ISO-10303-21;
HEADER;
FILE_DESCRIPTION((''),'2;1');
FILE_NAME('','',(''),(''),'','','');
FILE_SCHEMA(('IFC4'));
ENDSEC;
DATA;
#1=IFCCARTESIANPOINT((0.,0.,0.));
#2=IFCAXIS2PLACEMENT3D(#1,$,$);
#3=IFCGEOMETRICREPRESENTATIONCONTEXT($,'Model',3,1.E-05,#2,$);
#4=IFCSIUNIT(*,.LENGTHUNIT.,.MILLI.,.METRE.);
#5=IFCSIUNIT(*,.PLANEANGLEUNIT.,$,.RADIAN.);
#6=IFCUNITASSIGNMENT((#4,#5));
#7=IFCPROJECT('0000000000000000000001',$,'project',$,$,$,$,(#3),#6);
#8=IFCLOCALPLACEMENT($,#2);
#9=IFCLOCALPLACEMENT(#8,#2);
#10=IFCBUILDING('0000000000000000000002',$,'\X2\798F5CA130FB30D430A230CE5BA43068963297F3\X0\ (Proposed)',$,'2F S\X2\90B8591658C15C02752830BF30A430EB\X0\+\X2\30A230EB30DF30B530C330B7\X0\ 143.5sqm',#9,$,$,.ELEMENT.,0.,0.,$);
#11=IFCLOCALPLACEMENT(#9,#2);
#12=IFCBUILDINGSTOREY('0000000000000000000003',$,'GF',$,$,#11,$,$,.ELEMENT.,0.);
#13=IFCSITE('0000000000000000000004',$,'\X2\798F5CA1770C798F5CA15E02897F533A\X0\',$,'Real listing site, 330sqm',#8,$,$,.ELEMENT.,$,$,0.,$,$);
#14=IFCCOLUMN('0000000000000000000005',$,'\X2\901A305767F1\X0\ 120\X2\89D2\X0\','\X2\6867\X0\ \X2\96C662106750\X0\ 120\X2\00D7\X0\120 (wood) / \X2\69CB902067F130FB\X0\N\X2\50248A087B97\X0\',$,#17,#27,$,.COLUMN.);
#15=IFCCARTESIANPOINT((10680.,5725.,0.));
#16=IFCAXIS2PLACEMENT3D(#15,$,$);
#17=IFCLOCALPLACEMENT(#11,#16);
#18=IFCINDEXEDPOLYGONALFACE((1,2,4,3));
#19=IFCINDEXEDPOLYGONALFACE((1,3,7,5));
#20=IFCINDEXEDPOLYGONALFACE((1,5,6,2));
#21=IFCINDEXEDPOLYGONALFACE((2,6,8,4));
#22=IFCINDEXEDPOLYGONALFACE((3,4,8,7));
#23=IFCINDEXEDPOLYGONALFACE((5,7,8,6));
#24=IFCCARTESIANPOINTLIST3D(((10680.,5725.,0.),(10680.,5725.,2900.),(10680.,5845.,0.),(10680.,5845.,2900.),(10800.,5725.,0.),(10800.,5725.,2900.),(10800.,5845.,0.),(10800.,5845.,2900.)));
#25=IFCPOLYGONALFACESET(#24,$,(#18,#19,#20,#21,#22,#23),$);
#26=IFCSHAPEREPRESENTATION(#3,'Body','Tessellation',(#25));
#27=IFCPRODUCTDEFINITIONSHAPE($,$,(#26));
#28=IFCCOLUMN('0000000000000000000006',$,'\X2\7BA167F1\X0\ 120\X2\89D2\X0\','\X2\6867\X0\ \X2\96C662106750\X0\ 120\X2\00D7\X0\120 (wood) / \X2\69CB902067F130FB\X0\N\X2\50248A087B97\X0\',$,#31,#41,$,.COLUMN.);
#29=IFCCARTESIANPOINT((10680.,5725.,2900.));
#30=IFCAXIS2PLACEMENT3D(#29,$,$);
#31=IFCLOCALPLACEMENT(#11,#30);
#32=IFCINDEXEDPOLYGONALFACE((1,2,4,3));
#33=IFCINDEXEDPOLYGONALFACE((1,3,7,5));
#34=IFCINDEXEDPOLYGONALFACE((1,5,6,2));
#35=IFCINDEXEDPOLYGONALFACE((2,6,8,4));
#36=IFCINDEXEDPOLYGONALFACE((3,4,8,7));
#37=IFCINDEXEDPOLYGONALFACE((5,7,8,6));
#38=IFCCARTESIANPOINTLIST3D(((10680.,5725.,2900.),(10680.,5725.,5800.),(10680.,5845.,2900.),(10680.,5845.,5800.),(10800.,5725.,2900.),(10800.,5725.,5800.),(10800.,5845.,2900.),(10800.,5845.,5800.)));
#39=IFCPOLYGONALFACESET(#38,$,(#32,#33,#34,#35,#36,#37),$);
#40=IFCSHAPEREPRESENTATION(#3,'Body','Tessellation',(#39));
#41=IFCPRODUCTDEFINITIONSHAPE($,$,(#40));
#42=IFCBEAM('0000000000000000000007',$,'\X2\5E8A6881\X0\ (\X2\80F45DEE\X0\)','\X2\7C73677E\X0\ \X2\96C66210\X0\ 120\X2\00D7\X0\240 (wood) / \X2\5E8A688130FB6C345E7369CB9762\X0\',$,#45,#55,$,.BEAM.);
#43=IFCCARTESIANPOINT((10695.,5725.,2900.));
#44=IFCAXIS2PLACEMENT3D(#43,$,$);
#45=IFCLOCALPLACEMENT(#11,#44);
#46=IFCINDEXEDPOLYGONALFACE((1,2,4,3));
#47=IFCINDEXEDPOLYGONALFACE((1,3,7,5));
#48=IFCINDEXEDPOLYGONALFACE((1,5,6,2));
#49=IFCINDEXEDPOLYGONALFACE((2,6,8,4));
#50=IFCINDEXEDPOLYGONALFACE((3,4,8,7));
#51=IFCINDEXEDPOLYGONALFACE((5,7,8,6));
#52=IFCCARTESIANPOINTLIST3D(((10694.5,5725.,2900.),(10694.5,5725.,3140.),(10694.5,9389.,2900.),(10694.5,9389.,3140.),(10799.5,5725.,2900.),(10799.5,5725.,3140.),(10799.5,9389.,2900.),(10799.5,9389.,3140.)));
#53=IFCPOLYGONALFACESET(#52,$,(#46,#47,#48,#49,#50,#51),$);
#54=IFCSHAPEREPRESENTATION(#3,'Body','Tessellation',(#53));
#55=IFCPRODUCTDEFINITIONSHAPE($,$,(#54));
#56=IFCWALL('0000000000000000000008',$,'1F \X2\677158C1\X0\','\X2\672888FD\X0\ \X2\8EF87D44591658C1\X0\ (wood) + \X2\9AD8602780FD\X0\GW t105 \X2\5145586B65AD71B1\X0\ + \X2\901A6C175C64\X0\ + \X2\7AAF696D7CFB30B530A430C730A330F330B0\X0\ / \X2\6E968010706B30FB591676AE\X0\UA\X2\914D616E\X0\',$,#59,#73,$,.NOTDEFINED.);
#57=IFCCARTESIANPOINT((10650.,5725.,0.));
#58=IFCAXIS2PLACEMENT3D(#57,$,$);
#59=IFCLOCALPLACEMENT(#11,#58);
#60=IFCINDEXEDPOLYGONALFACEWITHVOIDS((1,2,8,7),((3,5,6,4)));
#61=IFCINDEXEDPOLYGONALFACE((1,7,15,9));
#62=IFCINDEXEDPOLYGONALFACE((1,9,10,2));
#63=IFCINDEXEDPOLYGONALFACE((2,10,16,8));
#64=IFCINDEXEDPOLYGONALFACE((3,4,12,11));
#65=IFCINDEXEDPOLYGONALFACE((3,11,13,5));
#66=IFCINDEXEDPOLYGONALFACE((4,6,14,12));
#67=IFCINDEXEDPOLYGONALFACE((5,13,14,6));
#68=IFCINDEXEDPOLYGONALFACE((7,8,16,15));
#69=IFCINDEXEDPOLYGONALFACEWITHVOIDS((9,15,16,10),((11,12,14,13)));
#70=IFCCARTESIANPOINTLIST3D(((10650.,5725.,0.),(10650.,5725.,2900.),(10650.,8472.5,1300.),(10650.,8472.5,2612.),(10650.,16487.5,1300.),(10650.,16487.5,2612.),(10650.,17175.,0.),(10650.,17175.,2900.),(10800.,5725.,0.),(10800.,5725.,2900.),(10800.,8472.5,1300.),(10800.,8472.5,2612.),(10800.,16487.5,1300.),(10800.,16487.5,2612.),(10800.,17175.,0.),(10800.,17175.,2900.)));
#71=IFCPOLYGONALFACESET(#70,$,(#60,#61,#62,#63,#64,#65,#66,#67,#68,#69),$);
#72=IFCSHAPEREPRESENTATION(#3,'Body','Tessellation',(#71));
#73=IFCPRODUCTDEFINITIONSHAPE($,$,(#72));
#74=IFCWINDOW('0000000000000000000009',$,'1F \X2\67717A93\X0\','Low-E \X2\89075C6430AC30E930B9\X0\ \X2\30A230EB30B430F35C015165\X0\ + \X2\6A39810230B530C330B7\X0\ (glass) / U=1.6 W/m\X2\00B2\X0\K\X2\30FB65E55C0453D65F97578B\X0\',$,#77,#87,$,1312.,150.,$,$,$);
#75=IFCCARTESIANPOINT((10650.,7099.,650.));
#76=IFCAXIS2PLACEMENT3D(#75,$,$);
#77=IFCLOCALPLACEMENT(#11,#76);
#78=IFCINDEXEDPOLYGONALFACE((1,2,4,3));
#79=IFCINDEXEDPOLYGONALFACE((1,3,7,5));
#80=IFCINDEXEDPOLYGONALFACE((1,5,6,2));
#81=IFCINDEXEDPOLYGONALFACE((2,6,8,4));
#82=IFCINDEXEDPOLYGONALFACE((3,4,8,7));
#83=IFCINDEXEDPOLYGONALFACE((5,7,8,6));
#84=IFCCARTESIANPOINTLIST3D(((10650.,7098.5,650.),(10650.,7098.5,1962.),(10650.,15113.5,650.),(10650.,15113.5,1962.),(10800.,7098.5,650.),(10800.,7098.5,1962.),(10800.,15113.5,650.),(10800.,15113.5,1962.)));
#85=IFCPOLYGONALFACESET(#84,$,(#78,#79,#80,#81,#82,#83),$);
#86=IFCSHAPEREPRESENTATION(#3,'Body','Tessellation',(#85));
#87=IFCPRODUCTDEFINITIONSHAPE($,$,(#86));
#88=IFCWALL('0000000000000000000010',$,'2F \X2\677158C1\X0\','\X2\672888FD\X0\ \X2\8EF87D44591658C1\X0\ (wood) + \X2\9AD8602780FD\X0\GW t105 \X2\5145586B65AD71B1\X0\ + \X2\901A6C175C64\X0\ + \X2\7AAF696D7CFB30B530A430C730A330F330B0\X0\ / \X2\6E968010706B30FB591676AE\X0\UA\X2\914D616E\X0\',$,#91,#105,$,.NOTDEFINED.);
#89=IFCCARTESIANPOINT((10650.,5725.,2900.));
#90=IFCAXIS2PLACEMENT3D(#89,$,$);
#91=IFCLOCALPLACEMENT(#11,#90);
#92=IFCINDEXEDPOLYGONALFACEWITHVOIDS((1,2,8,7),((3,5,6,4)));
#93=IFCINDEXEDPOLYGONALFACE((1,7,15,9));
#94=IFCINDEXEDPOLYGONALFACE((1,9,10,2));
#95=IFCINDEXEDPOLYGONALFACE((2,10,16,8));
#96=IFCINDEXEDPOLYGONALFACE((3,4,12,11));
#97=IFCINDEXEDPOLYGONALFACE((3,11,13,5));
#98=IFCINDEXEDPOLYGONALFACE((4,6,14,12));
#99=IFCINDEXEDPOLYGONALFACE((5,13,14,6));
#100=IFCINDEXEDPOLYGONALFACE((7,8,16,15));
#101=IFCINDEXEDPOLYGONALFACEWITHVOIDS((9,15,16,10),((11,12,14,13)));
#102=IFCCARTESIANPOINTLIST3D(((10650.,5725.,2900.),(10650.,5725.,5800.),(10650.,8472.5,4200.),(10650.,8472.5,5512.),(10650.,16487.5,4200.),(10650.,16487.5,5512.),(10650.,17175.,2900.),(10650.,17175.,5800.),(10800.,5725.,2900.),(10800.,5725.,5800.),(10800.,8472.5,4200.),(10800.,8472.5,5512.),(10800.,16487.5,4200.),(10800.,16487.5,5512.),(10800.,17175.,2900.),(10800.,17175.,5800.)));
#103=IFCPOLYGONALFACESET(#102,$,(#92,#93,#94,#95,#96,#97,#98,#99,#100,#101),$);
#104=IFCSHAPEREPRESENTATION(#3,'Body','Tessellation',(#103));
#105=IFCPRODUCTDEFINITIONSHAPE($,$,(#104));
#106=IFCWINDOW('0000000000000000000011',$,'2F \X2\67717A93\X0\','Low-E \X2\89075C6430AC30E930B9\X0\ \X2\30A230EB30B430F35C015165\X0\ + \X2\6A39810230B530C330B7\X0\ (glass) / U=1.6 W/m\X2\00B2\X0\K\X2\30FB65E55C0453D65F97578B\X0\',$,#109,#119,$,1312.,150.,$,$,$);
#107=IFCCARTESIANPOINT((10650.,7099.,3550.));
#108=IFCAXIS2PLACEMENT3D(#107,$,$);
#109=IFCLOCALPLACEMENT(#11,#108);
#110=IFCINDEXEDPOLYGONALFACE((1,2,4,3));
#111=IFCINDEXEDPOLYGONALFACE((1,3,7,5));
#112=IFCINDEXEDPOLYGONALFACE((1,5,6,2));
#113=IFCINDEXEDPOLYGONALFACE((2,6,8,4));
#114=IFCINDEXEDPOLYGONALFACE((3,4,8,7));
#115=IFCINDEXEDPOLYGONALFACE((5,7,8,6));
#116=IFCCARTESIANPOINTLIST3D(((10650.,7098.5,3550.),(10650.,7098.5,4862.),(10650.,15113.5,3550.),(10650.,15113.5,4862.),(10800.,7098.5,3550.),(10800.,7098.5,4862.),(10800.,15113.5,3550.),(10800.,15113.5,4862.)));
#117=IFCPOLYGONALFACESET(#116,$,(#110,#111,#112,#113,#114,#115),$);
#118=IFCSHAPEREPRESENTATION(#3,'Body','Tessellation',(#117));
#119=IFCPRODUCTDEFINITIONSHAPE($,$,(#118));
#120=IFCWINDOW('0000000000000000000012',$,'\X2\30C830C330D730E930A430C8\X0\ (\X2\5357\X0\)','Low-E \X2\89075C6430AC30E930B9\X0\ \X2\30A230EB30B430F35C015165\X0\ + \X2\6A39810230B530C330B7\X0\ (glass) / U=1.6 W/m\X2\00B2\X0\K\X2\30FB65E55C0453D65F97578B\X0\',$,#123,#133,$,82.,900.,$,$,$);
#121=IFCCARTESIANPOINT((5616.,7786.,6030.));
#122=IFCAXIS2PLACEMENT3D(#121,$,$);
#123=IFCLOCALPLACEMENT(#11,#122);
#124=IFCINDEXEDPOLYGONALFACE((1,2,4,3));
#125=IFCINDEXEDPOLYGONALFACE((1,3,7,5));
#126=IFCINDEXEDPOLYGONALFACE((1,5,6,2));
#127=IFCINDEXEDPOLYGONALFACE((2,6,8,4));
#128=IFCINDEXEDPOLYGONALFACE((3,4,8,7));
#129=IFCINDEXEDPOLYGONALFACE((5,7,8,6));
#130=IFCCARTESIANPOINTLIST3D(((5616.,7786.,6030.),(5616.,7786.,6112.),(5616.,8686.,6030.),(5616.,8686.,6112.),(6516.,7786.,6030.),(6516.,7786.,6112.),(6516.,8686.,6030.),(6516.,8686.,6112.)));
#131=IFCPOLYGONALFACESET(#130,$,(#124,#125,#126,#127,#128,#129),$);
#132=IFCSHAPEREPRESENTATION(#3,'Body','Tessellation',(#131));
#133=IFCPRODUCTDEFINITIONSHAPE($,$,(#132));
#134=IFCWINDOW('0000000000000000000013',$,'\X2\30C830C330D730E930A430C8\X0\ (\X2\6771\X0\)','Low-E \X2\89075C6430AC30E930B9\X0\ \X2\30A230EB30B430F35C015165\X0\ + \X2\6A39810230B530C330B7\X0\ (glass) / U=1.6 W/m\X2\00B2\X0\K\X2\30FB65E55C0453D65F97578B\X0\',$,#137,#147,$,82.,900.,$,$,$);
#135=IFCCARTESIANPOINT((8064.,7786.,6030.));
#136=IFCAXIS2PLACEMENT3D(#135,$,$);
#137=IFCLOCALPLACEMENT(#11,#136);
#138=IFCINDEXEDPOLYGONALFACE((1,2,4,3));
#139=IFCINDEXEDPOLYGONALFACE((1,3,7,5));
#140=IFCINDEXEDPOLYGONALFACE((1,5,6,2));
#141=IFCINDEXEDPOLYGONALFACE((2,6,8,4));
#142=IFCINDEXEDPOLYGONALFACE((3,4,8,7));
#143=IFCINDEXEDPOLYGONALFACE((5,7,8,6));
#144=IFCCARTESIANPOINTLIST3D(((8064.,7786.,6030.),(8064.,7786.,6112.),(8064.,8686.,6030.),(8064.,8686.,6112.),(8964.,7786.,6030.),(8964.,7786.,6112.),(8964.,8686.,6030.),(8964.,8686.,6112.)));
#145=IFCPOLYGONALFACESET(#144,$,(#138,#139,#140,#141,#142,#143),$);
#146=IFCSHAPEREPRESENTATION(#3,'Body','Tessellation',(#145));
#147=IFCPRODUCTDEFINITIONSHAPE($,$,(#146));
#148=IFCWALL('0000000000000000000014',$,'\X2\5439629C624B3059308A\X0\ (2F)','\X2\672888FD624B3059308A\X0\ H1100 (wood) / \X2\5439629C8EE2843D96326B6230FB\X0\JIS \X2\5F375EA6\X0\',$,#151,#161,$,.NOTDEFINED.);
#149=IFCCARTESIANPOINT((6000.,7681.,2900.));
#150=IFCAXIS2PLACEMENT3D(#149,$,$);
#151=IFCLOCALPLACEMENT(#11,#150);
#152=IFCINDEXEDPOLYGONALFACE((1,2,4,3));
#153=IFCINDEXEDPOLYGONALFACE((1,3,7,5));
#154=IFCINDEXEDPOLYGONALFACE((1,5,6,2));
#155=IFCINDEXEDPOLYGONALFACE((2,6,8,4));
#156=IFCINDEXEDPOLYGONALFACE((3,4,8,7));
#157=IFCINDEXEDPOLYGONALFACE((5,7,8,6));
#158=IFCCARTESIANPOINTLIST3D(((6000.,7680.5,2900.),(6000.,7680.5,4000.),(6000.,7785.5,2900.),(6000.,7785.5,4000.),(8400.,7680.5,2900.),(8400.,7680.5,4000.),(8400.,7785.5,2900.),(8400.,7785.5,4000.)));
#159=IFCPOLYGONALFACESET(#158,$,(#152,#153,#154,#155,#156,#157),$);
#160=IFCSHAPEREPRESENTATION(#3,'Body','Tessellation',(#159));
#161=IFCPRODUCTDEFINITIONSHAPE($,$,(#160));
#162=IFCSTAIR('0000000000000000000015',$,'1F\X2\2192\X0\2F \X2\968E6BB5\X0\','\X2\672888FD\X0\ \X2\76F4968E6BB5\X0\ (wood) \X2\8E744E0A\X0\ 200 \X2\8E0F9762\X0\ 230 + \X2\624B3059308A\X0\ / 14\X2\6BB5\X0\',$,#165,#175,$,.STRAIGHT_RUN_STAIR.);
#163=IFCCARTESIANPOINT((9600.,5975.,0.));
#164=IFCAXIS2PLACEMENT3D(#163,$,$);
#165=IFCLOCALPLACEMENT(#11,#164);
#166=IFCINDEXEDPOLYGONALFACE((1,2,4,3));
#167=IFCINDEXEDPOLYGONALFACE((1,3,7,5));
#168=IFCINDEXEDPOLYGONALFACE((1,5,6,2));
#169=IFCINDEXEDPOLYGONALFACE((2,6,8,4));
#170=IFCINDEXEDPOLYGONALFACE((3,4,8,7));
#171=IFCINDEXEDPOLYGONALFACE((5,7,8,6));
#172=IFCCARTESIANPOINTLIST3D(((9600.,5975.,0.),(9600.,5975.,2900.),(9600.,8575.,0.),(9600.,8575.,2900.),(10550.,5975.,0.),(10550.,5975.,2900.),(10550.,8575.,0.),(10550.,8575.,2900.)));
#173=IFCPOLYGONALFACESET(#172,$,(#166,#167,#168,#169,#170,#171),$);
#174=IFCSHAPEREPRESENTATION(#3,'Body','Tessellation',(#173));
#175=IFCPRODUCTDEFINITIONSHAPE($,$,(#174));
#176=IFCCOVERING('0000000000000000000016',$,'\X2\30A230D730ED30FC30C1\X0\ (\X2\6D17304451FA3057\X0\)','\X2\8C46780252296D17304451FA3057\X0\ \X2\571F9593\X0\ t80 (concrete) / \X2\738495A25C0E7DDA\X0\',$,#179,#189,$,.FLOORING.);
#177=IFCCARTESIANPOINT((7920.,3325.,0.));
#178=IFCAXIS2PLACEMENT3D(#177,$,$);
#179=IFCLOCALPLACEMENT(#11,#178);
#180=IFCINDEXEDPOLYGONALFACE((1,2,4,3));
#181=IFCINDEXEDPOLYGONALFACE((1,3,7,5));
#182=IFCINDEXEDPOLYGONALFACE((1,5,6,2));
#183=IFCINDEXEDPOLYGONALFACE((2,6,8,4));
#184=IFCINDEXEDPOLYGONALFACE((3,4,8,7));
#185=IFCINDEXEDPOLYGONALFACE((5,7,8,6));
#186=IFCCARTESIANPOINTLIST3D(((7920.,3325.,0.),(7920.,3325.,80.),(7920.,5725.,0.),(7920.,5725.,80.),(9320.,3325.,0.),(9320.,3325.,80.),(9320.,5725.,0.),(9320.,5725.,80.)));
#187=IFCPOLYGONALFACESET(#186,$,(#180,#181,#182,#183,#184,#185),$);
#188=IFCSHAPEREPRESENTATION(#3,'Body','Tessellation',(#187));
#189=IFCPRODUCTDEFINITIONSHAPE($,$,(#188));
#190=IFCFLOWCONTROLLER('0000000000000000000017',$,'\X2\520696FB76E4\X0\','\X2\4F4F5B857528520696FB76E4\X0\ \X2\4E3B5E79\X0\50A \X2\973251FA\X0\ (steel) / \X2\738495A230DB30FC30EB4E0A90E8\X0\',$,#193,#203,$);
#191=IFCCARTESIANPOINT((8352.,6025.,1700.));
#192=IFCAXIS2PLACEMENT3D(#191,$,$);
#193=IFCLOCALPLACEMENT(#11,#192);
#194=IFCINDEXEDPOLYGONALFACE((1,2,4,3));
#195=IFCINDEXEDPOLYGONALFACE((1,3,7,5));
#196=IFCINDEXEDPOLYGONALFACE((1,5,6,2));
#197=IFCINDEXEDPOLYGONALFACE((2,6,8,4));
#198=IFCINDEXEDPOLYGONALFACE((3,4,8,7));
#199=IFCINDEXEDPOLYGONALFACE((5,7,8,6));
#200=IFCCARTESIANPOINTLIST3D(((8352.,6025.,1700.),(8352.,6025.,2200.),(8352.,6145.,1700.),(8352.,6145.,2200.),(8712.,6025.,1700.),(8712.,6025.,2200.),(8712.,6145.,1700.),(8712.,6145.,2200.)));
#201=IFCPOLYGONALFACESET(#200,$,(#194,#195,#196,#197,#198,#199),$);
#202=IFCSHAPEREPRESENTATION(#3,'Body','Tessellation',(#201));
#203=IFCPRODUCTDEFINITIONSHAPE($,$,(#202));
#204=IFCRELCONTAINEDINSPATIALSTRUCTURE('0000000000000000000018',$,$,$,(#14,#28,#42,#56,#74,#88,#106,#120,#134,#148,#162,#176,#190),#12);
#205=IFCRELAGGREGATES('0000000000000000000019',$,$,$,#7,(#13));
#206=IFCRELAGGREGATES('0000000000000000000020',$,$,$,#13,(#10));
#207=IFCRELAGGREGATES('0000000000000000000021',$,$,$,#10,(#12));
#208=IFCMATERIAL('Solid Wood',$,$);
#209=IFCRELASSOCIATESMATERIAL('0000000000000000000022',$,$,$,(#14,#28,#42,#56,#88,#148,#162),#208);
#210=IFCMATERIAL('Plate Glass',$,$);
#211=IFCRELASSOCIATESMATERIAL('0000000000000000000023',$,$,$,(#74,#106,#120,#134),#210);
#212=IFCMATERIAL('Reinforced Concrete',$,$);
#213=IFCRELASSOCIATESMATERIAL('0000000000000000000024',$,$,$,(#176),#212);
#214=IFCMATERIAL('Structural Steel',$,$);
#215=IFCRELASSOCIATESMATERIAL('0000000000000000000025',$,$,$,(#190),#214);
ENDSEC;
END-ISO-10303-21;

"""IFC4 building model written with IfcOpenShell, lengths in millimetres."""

from ifc_helpers import new_model, si_unit, frame, frame_2d, origin, place, context, project, spatial, rectangle, extrude, material, element, fill, save


model = new_model("IFC4")

# Units and contexts
model_context = context("Model", 3, precision=1e-05, world=origin())
ifc_project = project(units=[si_unit("LENGTHUNIT", "METRE", prefix="MILLI"), si_unit("PLANEANGLEUNIT", "RADIAN")], contexts=[model_context])

# Site, building, storey
site_placement = place(None, origin())
site = spatial("IfcSite", under=ifc_project, at=site_placement, Name="福岡県福岡市西区", ObjectType="Real listing site, 330sqm", CompositionType="ELEMENT", RefElevation=0.0)
building_placement = place(site_placement, origin())
building = spatial("IfcBuilding", under=site, at=building_placement, Name="福岡・ピアノ室と防音 (Proposed)", ObjectType="2F S邸外壁専用タイル+アルミサッシ 143.5sqm", CompositionType="ELEMENT", ElevationOfRefHeight=0.0, ElevationOfTerrain=0.0)
storey_placement = place(building_placement, origin())
storey = spatial("IfcBuildingStorey", under=building, at=storey_placement, Name="GF", CompositionType="ELEMENT", Elevation=0.0)

# Columns
ifc_material_1 = material(Name="Solid Wood")
column_1_placement = place(storey_placement, frame((10680.0, 5725.0, 0.0)))
element("IfcColumn", 1, at=column_1_placement, inside=storey, material=ifc_material_1, Name="通し柱 120角", Description="桧 集成材 120×120 (wood) / 構造柱・N値計算", PredefinedType="COLUMN", context=model_context, shape_type="SweptSolid", body=[
    extrude(rectangle(XDim=120.0, YDim=120.0, at=frame_2d((60.0, 60.0))), frame((10680.0, 5725.0, 0.0)), (0.0, 0.0, 1.0), 2900.0),
])
column_2_placement = place(storey_placement, frame((10680.0, 5725.0, 2900.0)))
element("IfcColumn", 2, at=column_2_placement, inside=storey, material=ifc_material_1, Name="管柱 120角", Description="桧 集成材 120×120 (wood) / 構造柱・N値計算", PredefinedType="COLUMN", context=model_context, shape_type="SweptSolid", body=[
    extrude(rectangle(XDim=120.0, YDim=120.0, at=frame_2d((60.0, 60.0))), frame((10680.0, 5725.0, 2900.0)), (0.0, 0.0, 1.0), 2900.0),
])

# Beam
beam_1_placement = place(storey_placement, frame((10695.0, 5725.0, 2900.0)))
element("IfcBeam", 3, at=beam_1_placement, inside=storey, material=ifc_material_1, Name="床梁 (胴差)", Description="米松 集成 120×240 (wood) / 床梁・水平構面", PredefinedType="BEAM", context=model_context, shape_type="SweptSolid", body=[
    extrude(rectangle(XDim=105.0, YDim=3664.0, at=frame_2d((52.0, 1832.0))), frame((10695.0, 5725.0, 2900.0)), (0.0, 0.0, 1.0), 240.0),
])

# Wall, opening, window
wall_1_placement = place(storey_placement, frame((10650.0, 5725.0, 0.0)))
wall_1 = element("IfcWall", 4, at=wall_1_placement, inside=storey, material=ifc_material_1, Name="1F 東壁", Description="木製 軸組外壁 (wood) + 高性能GW t105 充填断熱 + 通気層 + 窯業系サイディング / 準耐火・外皮UA配慮", PredefinedType="NOTDEFINED", context=model_context, shape_type="SweptSolid", body=[
    extrude(rectangle(XDim=150.0, YDim=11450.0, at=frame_2d((75.0, 5725.0))), frame((10650.0, 5725.0, 0.0)), (0.0, 0.0, 1.0), 2900.0),
])
opening_1_placement = place(storey_placement, frame((10650.0, 7099.0, 650.0)))
opening_1 = element("IfcOpeningElement", 5, at=opening_1_placement, cuts=wall_1, PredefinedType="NOTDEFINED", context=model_context, shape_type="SweptSolid", body=[
    extrude(rectangle(XDim=150.0, YDim=8015.0, at=frame_2d((75.0, 4007.0))), frame((10650.0, 7099.0, 650.0)), (0.0, 0.0, 1.0), 1312.0),
])
ifc_material_2 = material(Name="Plate Glass")
window_1_placement = place(storey_placement, frame((10650.0, 7099.0, 650.0)))
window_1 = element("IfcWindow", 6, at=window_1_placement, inside=storey, material=ifc_material_2, Name="1F 東窓", Description="Low-E 複層ガラス アルゴン封入 + 樹脂サッシ (glass) / U=1.6 W/m²K・日射取得型", OverallHeight=1312.0, OverallWidth=150.0, context=model_context, shape_type="SweptSolid", body=[
    extrude(rectangle(XDim=150.0, YDim=8015.0, at=frame_2d((75.0, 4007.0))), frame((10650.0, 7099.0, 650.0)), (0.0, 0.0, 1.0), 1312.0),
])
fill(opening_1, window_1)

# Wall, opening, window
wall_2_placement = place(storey_placement, frame((10650.0, 5725.0, 2900.0)))
wall_2 = element("IfcWall", 7, at=wall_2_placement, inside=storey, material=ifc_material_1, Name="2F 東壁", Description="木製 軸組外壁 (wood) + 高性能GW t105 充填断熱 + 通気層 + 窯業系サイディング / 準耐火・外皮UA配慮", PredefinedType="NOTDEFINED", context=model_context, shape_type="SweptSolid", body=[
    extrude(rectangle(XDim=150.0, YDim=11450.0, at=frame_2d((75.0, 5725.0))), frame((10650.0, 5725.0, 2900.0)), (0.0, 0.0, 1.0), 2900.0),
])
opening_2_placement = place(storey_placement, frame((10650.0, 7099.0, 3550.0)))
opening_2 = element("IfcOpeningElement", 8, at=opening_2_placement, cuts=wall_2, PredefinedType="NOTDEFINED", context=model_context, shape_type="SweptSolid", body=[
    extrude(rectangle(XDim=150.0, YDim=8015.0, at=frame_2d((75.0, 4007.0))), frame((10650.0, 7099.0, 3550.0)), (0.0, 0.0, 1.0), 1312.0),
])
window_2_placement = place(storey_placement, frame((10650.0, 7099.0, 3550.0)))
window_2 = element("IfcWindow", 9, at=window_2_placement, inside=storey, material=ifc_material_2, Name="2F 東窓", Description="Low-E 複層ガラス アルゴン封入 + 樹脂サッシ (glass) / U=1.6 W/m²K・日射取得型", OverallHeight=1312.0, OverallWidth=150.0, context=model_context, shape_type="SweptSolid", body=[
    extrude(rectangle(XDim=150.0, YDim=8015.0, at=frame_2d((75.0, 4007.0))), frame((10650.0, 7099.0, 3550.0)), (0.0, 0.0, 1.0), 1312.0),
])
fill(opening_2, window_2)

# Windows
window_3_placement = place(storey_placement, frame((5616.0, 7786.0, 6030.0)))
element("IfcWindow", 10, at=window_3_placement, inside=storey, material=ifc_material_2, Name="トップライト (南)", Description="Low-E 複層ガラス アルゴン封入 + 樹脂サッシ (glass) / U=1.6 W/m²K・日射取得型", OverallHeight=82.0, OverallWidth=900.0, context=model_context, shape_type="SweptSolid", body=[
    extrude(rectangle(XDim=900.0, YDim=900.0, at=frame_2d((450.0, 450.0))), frame((5616.0, 7786.0, 6030.0)), (0.0, 0.0, 1.0), 82.0),
])
window_4_placement = place(storey_placement, frame((8064.0, 7786.0, 6030.0)))
element("IfcWindow", 11, at=window_4_placement, inside=storey, material=ifc_material_2, Name="トップライト (東)", Description="Low-E 複層ガラス アルゴン封入 + 樹脂サッシ (glass) / U=1.6 W/m²K・日射取得型", OverallHeight=82.0, OverallWidth=900.0, context=model_context, shape_type="SweptSolid", body=[
    extrude(rectangle(XDim=900.0, YDim=900.0, at=frame_2d((450.0, 450.0))), frame((8064.0, 7786.0, 6030.0)), (0.0, 0.0, 1.0), 82.0),
])

# Wall
wall_3_placement = place(storey_placement, frame((6000.0, 7681.0, 2900.0)))
element("IfcWall", 12, at=wall_3_placement, inside=storey, material=ifc_material_1, Name="吹抜手すり (2F)", Description="木製手すり H1100 (wood) / 吹抜転落防止・JIS 強度", PredefinedType="NOTDEFINED", context=model_context, shape_type="SweptSolid", body=[
    extrude(rectangle(XDim=2400.0, YDim=105.0, at=frame_2d((1200.0, 52.0))), frame((6000.0, 7681.0, 2900.0)), (0.0, 0.0, 1.0), 1100.0),
])

# Stair
stair_placement = place(storey_placement, frame((9600.0, 5975.0, 0.0)))
element("IfcStair", 13, at=stair_placement, inside=storey, material=ifc_material_1, Name="1F→2F 階段", Description="木製 直階段 (wood) 蹴上 200 踏面 230 + 手すり / 14段", PredefinedType="STRAIGHT_RUN_STAIR", context=model_context, shape_type="SweptSolid", body=[
    extrude(rectangle(XDim=950.0, YDim=2600.0, at=frame_2d((475.0, 1300.0))), frame((9600.0, 5975.0, 0.0)), (0.0, 0.0, 1.0), 2900.0),
])

# Covering
ifc_material_3 = material(Name="Reinforced Concrete")
covering_placement = place(storey_placement, frame((7920.0, 3325.0, 0.0)))
element("IfcCovering", 14, at=covering_placement, inside=storey, material=ifc_material_3, Name="アプローチ (洗い出し)", Description="豆砂利洗い出し 土間 t80 (concrete) / 玄関導線", PredefinedType="FLOORING", context=model_context, shape_type="SweptSolid", body=[
    extrude(rectangle(XDim=1400.0, YDim=2400.0, at=frame_2d((700.0, 1200.0))), frame((7920.0, 3325.0, 0.0)), (0.0, 0.0, 1.0), 80.0),
])

# Flow controller
ifc_material_4 = material(Name="Structural Steel")
flow_controller_placement = place(storey_placement, frame((8352.0, 6025.0, 1700.0)))
element("IfcFlowController", 15, at=flow_controller_placement, inside=storey, material=ifc_material_4, Name="分電盤", Description="住宅用分電盤 主幹50A 露出 (steel) / 玄関ホール上部", context=model_context, shape_type="SweptSolid", body=[
    extrude(rectangle(XDim=360.0, YDim=120.0, at=frame_2d((180.0, 60.0))), frame((8352.0, 6025.0, 1700.0)), (0.0, 0.0, 1.0), 500.0),
])

save(model, "model.ifc")
